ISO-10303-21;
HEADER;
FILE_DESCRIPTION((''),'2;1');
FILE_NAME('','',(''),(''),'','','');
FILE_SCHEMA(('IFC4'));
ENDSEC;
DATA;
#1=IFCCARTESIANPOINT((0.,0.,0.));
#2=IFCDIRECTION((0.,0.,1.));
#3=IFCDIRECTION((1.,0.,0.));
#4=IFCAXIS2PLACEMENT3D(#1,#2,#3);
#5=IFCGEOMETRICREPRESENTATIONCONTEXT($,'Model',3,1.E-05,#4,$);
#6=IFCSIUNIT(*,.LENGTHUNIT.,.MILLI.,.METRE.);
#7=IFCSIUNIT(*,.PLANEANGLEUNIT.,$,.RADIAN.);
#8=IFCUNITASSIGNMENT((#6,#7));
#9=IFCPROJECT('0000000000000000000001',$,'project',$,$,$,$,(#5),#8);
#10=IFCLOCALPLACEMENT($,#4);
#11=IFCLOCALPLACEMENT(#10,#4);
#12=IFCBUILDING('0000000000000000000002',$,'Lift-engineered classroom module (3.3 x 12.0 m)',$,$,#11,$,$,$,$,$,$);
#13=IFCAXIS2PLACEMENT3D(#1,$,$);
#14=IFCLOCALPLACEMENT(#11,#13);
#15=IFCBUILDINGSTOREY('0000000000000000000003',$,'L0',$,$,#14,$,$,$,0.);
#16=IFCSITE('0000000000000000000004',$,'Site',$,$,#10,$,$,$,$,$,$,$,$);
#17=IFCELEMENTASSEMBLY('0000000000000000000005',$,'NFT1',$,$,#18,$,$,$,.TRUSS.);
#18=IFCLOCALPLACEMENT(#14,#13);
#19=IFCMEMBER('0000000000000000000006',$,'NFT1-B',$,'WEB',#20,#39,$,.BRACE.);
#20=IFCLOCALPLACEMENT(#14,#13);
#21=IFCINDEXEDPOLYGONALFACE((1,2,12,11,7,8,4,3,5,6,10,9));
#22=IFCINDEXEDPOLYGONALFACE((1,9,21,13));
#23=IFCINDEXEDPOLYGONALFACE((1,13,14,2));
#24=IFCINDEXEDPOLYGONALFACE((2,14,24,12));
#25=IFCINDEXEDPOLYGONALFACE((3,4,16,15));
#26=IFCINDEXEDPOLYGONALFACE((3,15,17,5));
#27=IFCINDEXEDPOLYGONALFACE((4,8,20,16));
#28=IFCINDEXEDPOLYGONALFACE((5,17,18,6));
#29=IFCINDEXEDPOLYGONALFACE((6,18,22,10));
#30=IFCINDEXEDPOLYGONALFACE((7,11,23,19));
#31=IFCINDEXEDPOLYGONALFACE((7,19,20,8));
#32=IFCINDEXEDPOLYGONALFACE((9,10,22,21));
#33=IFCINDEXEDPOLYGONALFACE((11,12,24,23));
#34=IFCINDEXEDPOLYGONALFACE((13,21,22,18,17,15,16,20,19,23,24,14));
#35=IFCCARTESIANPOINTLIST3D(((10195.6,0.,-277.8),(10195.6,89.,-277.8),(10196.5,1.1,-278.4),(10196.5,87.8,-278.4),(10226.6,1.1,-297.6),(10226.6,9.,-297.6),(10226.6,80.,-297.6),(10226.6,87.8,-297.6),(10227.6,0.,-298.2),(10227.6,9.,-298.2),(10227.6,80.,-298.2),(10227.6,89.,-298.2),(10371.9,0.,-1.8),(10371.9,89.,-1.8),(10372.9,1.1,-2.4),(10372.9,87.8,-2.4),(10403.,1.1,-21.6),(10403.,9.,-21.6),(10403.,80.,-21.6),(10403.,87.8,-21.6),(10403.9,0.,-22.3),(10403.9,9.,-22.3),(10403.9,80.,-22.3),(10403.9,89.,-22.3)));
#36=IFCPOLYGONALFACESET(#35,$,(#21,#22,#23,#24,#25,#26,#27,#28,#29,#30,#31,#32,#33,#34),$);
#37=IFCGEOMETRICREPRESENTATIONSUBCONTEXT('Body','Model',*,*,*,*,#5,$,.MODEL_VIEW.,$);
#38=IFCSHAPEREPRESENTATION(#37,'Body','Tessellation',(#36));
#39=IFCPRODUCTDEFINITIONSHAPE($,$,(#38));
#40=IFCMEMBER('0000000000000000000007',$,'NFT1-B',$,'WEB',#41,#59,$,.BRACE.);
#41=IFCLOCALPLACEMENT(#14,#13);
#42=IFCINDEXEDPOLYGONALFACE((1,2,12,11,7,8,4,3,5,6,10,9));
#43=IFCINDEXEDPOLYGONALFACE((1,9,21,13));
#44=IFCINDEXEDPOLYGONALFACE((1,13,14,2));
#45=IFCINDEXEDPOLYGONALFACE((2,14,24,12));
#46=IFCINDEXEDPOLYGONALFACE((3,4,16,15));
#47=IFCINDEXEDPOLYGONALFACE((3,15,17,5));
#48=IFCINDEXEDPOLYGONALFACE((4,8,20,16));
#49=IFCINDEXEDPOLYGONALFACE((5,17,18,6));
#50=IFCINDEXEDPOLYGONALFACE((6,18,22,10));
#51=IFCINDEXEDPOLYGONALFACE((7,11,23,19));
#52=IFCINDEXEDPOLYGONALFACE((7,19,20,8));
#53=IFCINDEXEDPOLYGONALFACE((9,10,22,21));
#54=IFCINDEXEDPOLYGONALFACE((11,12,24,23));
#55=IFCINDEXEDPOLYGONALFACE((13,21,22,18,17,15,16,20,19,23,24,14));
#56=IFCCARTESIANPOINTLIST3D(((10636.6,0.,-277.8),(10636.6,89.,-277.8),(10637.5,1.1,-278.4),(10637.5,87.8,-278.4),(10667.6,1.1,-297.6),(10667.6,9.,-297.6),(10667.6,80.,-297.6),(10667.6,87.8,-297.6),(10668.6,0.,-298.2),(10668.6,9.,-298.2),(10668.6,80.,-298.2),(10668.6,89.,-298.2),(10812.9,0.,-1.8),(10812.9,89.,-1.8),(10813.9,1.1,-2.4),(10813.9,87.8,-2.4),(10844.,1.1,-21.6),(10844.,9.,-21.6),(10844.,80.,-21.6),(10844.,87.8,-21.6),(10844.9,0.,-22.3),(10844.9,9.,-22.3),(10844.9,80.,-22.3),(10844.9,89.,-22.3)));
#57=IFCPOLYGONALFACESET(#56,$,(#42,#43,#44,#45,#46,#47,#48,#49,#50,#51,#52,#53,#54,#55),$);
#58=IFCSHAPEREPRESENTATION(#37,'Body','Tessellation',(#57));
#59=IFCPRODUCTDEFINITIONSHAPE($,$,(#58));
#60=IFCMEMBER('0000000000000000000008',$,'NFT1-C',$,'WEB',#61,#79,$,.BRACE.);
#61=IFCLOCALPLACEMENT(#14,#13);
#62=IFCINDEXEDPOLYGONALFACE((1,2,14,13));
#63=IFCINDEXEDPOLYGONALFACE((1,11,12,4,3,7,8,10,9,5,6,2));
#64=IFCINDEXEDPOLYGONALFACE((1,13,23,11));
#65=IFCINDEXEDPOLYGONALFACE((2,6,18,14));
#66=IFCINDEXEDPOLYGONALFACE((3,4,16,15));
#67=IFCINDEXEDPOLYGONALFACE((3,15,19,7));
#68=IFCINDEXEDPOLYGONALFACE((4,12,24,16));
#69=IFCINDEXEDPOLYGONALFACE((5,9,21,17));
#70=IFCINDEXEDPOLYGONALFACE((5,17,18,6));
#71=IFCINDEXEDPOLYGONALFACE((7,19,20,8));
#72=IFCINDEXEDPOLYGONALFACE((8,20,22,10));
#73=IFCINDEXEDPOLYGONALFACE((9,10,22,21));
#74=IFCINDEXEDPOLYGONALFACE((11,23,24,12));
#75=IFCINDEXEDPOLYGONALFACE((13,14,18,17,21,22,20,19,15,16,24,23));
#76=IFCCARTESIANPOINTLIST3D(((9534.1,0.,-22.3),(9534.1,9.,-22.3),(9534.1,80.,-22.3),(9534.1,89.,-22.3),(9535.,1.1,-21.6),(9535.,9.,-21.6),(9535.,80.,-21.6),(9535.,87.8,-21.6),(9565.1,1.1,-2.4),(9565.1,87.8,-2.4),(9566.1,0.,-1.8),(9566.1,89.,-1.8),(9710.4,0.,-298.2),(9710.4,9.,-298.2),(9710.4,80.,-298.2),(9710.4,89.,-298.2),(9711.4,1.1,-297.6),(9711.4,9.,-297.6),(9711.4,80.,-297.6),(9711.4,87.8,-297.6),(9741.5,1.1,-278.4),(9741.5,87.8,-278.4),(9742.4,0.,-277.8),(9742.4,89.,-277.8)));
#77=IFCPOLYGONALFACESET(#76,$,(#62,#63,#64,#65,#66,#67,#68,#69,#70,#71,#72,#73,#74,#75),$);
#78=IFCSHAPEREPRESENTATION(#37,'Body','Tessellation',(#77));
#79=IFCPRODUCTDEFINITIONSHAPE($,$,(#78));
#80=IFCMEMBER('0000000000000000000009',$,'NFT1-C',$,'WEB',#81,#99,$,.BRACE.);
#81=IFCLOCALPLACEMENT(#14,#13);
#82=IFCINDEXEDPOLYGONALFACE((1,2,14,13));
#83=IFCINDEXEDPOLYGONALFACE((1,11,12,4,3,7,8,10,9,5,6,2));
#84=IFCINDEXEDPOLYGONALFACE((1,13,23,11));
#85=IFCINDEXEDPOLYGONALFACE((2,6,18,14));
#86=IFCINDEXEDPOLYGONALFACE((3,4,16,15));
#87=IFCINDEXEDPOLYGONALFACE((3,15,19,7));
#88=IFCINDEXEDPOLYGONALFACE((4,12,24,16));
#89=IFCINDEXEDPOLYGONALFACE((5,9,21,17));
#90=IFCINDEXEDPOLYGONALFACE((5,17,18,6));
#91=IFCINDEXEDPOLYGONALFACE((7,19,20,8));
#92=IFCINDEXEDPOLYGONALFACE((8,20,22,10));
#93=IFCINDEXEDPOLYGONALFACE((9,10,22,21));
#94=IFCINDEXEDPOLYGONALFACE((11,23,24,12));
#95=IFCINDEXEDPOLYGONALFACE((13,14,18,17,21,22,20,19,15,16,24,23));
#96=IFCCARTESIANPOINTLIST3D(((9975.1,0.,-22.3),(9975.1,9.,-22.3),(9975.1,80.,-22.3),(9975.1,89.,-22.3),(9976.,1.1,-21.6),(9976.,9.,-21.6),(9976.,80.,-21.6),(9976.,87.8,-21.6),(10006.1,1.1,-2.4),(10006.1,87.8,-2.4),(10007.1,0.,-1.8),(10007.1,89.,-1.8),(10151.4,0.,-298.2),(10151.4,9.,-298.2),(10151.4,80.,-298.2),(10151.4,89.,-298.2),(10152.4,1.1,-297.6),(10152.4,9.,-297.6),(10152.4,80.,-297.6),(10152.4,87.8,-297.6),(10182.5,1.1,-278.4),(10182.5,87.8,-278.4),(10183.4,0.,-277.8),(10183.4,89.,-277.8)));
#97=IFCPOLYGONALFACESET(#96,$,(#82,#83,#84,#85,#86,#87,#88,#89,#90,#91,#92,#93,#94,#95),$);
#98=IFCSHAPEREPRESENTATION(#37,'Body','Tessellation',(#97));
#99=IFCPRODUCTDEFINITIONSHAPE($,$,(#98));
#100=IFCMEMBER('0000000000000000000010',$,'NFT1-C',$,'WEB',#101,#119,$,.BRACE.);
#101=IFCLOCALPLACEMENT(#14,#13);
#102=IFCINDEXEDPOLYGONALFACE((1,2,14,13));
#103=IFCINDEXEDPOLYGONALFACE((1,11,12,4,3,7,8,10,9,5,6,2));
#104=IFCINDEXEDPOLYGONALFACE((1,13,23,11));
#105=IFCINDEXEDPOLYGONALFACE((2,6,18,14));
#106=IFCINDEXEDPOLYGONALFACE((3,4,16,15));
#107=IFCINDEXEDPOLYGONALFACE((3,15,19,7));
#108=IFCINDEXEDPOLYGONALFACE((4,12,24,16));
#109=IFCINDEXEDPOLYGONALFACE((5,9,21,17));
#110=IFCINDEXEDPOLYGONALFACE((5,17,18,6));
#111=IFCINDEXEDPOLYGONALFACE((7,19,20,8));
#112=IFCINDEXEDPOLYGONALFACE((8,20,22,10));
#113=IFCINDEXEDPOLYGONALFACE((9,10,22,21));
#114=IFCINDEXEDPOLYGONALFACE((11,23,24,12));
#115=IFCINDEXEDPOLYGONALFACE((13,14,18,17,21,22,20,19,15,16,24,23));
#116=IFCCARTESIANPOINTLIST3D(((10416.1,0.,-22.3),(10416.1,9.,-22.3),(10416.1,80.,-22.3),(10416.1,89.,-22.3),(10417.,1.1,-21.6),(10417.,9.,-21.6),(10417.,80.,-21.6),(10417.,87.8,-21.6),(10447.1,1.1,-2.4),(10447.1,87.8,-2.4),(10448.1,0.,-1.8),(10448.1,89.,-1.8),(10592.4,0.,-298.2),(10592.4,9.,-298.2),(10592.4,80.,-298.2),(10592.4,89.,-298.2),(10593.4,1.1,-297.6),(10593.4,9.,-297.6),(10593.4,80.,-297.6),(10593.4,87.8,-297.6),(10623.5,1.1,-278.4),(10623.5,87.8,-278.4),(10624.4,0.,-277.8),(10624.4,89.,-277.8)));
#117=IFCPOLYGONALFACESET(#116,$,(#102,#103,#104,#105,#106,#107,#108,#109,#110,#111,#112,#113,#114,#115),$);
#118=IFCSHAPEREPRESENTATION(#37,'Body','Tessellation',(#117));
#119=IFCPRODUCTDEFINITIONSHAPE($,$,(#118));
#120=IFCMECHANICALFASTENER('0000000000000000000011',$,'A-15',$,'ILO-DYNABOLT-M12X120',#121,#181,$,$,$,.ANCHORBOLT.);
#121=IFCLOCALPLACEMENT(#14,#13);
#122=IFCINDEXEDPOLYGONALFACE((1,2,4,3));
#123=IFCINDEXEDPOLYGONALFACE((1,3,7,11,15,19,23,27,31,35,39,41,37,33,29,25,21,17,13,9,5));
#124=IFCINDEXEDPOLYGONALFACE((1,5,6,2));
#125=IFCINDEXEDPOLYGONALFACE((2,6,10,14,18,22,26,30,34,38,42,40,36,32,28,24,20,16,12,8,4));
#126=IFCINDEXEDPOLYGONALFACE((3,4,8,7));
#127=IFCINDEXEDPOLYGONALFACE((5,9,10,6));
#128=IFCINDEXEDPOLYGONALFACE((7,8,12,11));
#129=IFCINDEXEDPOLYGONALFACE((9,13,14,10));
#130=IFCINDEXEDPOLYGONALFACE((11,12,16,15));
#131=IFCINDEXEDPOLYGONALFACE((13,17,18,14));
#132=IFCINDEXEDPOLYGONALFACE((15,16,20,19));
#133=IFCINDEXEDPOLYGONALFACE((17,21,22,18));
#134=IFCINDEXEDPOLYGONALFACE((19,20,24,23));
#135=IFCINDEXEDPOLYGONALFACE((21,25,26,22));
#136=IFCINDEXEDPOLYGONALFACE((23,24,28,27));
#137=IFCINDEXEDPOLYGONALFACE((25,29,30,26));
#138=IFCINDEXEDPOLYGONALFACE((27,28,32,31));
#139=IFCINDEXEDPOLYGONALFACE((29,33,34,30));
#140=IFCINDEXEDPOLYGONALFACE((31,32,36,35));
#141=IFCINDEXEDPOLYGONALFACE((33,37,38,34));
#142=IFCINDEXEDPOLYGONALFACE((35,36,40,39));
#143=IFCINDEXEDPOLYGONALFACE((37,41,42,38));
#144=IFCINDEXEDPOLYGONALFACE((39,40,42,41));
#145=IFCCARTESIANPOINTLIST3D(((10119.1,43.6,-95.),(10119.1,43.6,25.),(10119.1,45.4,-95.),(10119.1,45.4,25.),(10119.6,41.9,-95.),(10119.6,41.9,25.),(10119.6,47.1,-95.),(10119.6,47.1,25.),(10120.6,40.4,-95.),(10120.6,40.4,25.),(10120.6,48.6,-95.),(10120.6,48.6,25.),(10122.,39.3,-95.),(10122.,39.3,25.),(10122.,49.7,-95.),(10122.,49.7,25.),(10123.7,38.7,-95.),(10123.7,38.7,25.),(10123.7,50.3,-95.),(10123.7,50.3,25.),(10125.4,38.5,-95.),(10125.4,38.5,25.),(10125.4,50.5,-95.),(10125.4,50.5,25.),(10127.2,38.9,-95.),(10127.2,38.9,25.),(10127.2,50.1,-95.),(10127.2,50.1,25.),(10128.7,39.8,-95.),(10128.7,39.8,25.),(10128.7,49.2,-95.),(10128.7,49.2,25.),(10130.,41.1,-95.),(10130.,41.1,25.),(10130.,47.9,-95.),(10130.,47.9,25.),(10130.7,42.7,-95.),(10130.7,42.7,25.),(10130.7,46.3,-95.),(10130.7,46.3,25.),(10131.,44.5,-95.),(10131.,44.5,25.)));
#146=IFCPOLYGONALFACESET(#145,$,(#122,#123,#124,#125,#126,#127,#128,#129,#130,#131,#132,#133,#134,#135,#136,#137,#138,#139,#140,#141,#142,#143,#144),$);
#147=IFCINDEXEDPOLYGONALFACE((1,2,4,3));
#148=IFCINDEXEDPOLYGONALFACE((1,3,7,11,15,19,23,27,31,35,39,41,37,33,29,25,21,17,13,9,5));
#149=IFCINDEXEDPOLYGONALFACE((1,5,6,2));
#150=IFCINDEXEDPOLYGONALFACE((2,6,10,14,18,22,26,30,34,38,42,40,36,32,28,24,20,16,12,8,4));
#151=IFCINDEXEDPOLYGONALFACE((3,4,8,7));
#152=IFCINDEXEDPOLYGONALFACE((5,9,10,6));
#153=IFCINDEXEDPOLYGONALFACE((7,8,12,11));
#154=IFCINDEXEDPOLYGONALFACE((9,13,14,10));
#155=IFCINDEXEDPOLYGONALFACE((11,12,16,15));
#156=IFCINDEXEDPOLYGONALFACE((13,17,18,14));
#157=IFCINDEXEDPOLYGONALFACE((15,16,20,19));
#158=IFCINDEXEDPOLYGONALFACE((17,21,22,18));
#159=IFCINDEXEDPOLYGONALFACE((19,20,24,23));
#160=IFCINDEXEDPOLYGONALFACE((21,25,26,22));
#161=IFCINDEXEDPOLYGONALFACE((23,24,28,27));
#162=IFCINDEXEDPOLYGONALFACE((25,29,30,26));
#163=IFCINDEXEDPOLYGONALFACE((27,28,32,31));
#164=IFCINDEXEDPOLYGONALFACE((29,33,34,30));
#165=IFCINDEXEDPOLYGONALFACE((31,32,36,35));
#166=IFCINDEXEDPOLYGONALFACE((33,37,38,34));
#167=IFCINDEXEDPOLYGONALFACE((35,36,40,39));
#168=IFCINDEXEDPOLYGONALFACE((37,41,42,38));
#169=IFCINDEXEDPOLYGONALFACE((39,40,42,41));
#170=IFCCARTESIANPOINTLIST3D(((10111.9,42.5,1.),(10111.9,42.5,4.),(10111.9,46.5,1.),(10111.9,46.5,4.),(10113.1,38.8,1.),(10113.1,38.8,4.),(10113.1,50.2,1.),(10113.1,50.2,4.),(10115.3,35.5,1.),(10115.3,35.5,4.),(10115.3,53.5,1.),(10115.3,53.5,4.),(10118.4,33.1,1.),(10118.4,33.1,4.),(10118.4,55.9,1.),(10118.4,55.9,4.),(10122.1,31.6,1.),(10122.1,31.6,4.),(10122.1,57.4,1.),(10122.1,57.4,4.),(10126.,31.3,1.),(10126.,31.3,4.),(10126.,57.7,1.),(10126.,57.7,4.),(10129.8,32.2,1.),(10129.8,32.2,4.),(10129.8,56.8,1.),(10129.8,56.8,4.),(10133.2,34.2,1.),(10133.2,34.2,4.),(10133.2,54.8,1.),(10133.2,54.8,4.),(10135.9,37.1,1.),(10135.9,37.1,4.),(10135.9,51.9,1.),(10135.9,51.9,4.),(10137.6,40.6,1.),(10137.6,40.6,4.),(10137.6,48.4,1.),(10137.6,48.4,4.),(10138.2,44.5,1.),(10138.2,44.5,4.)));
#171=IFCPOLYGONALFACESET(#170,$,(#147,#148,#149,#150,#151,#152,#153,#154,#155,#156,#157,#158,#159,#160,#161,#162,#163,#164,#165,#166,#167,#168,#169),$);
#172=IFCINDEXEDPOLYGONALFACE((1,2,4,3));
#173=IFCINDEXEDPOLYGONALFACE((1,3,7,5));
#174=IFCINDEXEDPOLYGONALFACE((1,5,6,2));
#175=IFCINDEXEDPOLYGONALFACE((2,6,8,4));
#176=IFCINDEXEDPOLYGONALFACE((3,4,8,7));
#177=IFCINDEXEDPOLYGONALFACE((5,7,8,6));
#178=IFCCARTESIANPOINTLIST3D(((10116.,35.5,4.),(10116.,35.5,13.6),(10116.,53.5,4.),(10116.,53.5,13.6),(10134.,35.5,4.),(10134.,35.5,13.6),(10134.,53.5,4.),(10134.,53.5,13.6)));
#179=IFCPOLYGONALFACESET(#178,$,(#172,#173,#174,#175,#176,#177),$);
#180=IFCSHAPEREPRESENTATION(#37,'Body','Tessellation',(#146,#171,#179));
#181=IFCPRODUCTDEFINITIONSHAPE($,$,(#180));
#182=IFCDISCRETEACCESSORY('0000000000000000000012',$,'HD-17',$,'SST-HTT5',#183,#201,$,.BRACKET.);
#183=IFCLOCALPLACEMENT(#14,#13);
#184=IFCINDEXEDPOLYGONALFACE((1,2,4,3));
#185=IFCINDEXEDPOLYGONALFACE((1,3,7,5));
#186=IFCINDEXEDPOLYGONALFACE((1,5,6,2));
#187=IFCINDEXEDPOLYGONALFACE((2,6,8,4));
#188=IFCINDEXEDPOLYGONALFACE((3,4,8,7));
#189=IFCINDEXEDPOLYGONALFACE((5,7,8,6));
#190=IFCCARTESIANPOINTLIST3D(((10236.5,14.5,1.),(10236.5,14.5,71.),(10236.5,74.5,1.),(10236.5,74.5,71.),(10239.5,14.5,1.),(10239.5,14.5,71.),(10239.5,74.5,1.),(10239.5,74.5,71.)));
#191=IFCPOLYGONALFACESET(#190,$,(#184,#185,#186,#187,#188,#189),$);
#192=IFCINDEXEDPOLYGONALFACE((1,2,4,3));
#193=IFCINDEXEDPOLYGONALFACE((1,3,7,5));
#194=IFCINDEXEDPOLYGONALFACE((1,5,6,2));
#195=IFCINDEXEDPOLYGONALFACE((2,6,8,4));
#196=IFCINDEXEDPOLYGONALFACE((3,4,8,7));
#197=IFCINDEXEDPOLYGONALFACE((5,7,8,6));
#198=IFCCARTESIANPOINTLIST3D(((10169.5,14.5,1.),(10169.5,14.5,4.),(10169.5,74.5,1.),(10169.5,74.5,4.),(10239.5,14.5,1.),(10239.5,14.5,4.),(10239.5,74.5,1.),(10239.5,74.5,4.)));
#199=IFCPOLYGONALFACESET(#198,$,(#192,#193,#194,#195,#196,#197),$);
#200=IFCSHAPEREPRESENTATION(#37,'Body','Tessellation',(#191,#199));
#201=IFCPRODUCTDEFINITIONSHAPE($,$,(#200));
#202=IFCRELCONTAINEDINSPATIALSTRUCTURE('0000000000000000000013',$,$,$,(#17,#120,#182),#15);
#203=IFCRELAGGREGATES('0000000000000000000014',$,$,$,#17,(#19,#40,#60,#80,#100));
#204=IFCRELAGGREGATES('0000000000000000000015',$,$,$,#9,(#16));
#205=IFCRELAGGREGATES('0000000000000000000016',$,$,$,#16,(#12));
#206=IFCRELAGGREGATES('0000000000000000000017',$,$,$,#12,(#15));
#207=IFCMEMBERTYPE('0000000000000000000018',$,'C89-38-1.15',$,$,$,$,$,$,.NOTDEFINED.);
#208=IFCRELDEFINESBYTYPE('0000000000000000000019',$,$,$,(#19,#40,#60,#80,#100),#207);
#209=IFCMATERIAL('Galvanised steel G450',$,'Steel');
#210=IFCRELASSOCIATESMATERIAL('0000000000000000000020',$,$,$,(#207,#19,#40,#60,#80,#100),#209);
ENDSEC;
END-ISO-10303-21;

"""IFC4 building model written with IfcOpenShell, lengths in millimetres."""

from ifc_helpers import new_model, si_unit, frame, frame_2d, origin, origin_with_axes, origin_2d, place, context, subcontext, project, spatial, rectangle, circle, c_section, extrude, material, material_profile, profile_set, profile_usage, type_object, element, aggregate, save


model = new_model("IFC4")

# Units and contexts
model_context = context("Model", 3, precision=1e-05, world=origin_with_axes())
body_context = subcontext(model_context, "Body", "Model", "MODEL_VIEW")
ifc_project = project(units=[si_unit("LENGTHUNIT", "METRE", prefix="MILLI"), si_unit("PLANEANGLEUNIT", "RADIAN")], contexts=[model_context])

# Site, building, storey
site_placement = place(None, origin_with_axes())
site = spatial("IfcSite", under=ifc_project, at=site_placement, Name="Site")
building_placement = place(site_placement, origin_with_axes())
building = spatial("IfcBuilding", under=site, at=building_placement, Name="Lift-engineered classroom module (3.3 x 12.0 m)")
storey_placement = place(building_placement, origin())
storey = spatial("IfcBuildingStorey", under=building, at=storey_placement, Name="L0", Elevation=0.0)

# Element assembly, members
ifc_material = material(Name="Galvanised steel G450", Category="Steel")
assembly_1_placement = place(storey_placement, frame((0.0, 44.5, -300.0)))
assembly_1 = element("IfcElementAssembly", 1, at=assembly_1_placement, inside=storey, Name="NFT1", PredefinedType="TRUSS")
ifc_material_profile_1 = material_profile(ifc_material, c_section(Depth=89.0, Width=38.0, WallThickness=1.1, Girth=9.0, at=origin_2d()), Name="C89-38-1.15")
ifc_profile_set_1 = profile_set([ifc_material_profile_1], Name="C89-38-1.15")
ifc_profile_usage_1 = profile_usage(ifc_profile_set_1)
member_type_1 = type_object("IfcMemberType", Name="C89-38-1.15", PredefinedType="NOTDEFINED", material=ifc_profile_set_1)
member_1_placement = place(assembly_1_placement, frame((10211.6, 0.0, 12.0), z_axis=(0.538459, 0.0, 0.842652), x_axis=(0.842652, 0.0, -0.538459)))
member_1 = element("IfcMember", 2, at=member_1_placement, type_object=member_type_1, material=ifc_profile_usage_1, Name="NFT1-B", ObjectType="WEB", PredefinedType="BRACE", context=body_context, shape_type="SweptSolid", body=[
    extrude(c_section(Depth=89.0, Width=38.0, WallThickness=1.1, Girth=9.0, at=origin_2d()), origin(), (0.0, 0.0, 1.0), 327.5),
])
member_2_placement = place(assembly_1_placement, frame((10652.6, 0.0, 12.0), z_axis=(0.538459, 0.0, 0.842652), x_axis=(0.842652, 0.0, -0.538459)))
member_2 = element("IfcMember", 3, at=member_2_placement, type_object=member_type_1, material=ifc_profile_usage_1, Name="NFT1-B", ObjectType="WEB", PredefinedType="BRACE", context=body_context, shape_type="SweptSolid", body=[
    extrude(c_section(Depth=89.0, Width=38.0, WallThickness=1.1, Girth=9.0, at=origin_2d()), origin(), (0.0, 0.0, 1.0), 327.5),
])
member_3_placement = place(assembly_1_placement, frame((9726.4, 0.0, 12.0), z_axis=(-0.538459, 0.0, 0.842652), x_axis=(-0.842652, 0.0, -0.538459)))
member_3 = element("IfcMember", 4, at=member_3_placement, type_object=member_type_1, material=ifc_profile_usage_1, Name="NFT1-C", ObjectType="WEB", PredefinedType="BRACE", context=body_context, shape_type="SweptSolid", body=[
    extrude(c_section(Depth=89.0, Width=38.0, WallThickness=1.1, Girth=9.0, at=origin_2d()), origin(), (0.0, 0.0, 1.0), 327.5),
])
member_4_placement = place(assembly_1_placement, frame((10167.4, 0.0, 12.0), z_axis=(-0.538459, 0.0, 0.842652), x_axis=(-0.842652, 0.0, -0.538459)))
member_4 = element("IfcMember", 5, at=member_4_placement, type_object=member_type_1, material=ifc_profile_usage_1, Name="NFT1-C", ObjectType="WEB", PredefinedType="BRACE", context=body_context, shape_type="SweptSolid", body=[
    extrude(c_section(Depth=89.0, Width=38.0, WallThickness=1.1, Girth=9.0, at=origin_2d()), origin(), (0.0, 0.0, 1.0), 327.5),
])
member_5_placement = place(assembly_1_placement, frame((10608.4, 0.0, 12.0), z_axis=(-0.538459, 0.0, 0.842652), x_axis=(-0.842652, 0.0, -0.538459)))
member_5 = element("IfcMember", 6, at=member_5_placement, type_object=member_type_1, material=ifc_profile_usage_1, Name="NFT1-C", ObjectType="WEB", PredefinedType="BRACE", context=body_context, shape_type="SweptSolid", body=[
    extrude(c_section(Depth=89.0, Width=38.0, WallThickness=1.1, Girth=9.0, at=origin_2d()), origin(), (0.0, 0.0, 1.0), 327.5),
])
aggregate(assembly_1, [member_1, member_2, member_3, member_4, member_5])

# Mechanical fastener
mechanical_fastener_placement = place(None, frame((10125.0, 44.5, 0.0), z_axis=(0.0, 0.0, 1.0), x_axis=(1.0, 0.0, 0.0)))
element("IfcMechanicalFastener", 7, at=mechanical_fastener_placement, inside=storey, Name="A-15", ObjectType="ILO-DYNABOLT-M12X120", PredefinedType="ANCHORBOLT", context=body_context, shape_type="SweptSolid", body=[
    extrude(circle(Radius=6.0, at=origin_2d()), frame((0.0, 0.0, -95.0), z_axis=(0.0, 0.0, 1.0), x_axis=(1.0, 0.0, 0.0)), (0.0, 0.0, 1.0), 120.0),
    extrude(circle(Radius=13.2, at=origin_2d()), frame((0.0, 0.0, 1.0), z_axis=(0.0, 0.0, 1.0), x_axis=(1.0, 0.0, 0.0)), (0.0, 0.0, 1.0), 3.0),
    extrude(rectangle(XDim=18.0, YDim=18.0, at=origin_2d()), frame((0.0, 0.0, 4.0), z_axis=(0.0, 0.0, 1.0), x_axis=(1.0, 0.0, 0.0)), (0.0, 0.0, 1.0), 9.6),
])

# Discrete accessory
discrete_accessory_placement = place(None, frame((10239.5, 44.5, 0.0), z_axis=(0.0, 0.0, 1.0), x_axis=(-1.0, 0.0, 0.0)))
element("IfcDiscreteAccessory", 8, at=discrete_accessory_placement, inside=storey, Name="HD-17", ObjectType="SST-HTT5", PredefinedType="BRACKET", context=body_context, shape_type="SweptSolid", body=[
    extrude(rectangle(XDim=3.0, YDim=60.0, at=frame_2d((1.5, 0.0))), frame((0.0, 0.0, 1.0), z_axis=(0.0, 0.0, 1.0), x_axis=(1.0, 0.0, 0.0)), (0.0, 0.0, 1.0), 70.0),
    extrude(rectangle(XDim=70.0, YDim=60.0, at=frame_2d((35.0, 0.0))), frame((0.0, 0.0, 1.0), z_axis=(0.0, 0.0, 1.0), x_axis=(1.0, 0.0, 0.0)), (0.0, 0.0, 1.0), 3.0),
])

save(model, "model.ifc")
